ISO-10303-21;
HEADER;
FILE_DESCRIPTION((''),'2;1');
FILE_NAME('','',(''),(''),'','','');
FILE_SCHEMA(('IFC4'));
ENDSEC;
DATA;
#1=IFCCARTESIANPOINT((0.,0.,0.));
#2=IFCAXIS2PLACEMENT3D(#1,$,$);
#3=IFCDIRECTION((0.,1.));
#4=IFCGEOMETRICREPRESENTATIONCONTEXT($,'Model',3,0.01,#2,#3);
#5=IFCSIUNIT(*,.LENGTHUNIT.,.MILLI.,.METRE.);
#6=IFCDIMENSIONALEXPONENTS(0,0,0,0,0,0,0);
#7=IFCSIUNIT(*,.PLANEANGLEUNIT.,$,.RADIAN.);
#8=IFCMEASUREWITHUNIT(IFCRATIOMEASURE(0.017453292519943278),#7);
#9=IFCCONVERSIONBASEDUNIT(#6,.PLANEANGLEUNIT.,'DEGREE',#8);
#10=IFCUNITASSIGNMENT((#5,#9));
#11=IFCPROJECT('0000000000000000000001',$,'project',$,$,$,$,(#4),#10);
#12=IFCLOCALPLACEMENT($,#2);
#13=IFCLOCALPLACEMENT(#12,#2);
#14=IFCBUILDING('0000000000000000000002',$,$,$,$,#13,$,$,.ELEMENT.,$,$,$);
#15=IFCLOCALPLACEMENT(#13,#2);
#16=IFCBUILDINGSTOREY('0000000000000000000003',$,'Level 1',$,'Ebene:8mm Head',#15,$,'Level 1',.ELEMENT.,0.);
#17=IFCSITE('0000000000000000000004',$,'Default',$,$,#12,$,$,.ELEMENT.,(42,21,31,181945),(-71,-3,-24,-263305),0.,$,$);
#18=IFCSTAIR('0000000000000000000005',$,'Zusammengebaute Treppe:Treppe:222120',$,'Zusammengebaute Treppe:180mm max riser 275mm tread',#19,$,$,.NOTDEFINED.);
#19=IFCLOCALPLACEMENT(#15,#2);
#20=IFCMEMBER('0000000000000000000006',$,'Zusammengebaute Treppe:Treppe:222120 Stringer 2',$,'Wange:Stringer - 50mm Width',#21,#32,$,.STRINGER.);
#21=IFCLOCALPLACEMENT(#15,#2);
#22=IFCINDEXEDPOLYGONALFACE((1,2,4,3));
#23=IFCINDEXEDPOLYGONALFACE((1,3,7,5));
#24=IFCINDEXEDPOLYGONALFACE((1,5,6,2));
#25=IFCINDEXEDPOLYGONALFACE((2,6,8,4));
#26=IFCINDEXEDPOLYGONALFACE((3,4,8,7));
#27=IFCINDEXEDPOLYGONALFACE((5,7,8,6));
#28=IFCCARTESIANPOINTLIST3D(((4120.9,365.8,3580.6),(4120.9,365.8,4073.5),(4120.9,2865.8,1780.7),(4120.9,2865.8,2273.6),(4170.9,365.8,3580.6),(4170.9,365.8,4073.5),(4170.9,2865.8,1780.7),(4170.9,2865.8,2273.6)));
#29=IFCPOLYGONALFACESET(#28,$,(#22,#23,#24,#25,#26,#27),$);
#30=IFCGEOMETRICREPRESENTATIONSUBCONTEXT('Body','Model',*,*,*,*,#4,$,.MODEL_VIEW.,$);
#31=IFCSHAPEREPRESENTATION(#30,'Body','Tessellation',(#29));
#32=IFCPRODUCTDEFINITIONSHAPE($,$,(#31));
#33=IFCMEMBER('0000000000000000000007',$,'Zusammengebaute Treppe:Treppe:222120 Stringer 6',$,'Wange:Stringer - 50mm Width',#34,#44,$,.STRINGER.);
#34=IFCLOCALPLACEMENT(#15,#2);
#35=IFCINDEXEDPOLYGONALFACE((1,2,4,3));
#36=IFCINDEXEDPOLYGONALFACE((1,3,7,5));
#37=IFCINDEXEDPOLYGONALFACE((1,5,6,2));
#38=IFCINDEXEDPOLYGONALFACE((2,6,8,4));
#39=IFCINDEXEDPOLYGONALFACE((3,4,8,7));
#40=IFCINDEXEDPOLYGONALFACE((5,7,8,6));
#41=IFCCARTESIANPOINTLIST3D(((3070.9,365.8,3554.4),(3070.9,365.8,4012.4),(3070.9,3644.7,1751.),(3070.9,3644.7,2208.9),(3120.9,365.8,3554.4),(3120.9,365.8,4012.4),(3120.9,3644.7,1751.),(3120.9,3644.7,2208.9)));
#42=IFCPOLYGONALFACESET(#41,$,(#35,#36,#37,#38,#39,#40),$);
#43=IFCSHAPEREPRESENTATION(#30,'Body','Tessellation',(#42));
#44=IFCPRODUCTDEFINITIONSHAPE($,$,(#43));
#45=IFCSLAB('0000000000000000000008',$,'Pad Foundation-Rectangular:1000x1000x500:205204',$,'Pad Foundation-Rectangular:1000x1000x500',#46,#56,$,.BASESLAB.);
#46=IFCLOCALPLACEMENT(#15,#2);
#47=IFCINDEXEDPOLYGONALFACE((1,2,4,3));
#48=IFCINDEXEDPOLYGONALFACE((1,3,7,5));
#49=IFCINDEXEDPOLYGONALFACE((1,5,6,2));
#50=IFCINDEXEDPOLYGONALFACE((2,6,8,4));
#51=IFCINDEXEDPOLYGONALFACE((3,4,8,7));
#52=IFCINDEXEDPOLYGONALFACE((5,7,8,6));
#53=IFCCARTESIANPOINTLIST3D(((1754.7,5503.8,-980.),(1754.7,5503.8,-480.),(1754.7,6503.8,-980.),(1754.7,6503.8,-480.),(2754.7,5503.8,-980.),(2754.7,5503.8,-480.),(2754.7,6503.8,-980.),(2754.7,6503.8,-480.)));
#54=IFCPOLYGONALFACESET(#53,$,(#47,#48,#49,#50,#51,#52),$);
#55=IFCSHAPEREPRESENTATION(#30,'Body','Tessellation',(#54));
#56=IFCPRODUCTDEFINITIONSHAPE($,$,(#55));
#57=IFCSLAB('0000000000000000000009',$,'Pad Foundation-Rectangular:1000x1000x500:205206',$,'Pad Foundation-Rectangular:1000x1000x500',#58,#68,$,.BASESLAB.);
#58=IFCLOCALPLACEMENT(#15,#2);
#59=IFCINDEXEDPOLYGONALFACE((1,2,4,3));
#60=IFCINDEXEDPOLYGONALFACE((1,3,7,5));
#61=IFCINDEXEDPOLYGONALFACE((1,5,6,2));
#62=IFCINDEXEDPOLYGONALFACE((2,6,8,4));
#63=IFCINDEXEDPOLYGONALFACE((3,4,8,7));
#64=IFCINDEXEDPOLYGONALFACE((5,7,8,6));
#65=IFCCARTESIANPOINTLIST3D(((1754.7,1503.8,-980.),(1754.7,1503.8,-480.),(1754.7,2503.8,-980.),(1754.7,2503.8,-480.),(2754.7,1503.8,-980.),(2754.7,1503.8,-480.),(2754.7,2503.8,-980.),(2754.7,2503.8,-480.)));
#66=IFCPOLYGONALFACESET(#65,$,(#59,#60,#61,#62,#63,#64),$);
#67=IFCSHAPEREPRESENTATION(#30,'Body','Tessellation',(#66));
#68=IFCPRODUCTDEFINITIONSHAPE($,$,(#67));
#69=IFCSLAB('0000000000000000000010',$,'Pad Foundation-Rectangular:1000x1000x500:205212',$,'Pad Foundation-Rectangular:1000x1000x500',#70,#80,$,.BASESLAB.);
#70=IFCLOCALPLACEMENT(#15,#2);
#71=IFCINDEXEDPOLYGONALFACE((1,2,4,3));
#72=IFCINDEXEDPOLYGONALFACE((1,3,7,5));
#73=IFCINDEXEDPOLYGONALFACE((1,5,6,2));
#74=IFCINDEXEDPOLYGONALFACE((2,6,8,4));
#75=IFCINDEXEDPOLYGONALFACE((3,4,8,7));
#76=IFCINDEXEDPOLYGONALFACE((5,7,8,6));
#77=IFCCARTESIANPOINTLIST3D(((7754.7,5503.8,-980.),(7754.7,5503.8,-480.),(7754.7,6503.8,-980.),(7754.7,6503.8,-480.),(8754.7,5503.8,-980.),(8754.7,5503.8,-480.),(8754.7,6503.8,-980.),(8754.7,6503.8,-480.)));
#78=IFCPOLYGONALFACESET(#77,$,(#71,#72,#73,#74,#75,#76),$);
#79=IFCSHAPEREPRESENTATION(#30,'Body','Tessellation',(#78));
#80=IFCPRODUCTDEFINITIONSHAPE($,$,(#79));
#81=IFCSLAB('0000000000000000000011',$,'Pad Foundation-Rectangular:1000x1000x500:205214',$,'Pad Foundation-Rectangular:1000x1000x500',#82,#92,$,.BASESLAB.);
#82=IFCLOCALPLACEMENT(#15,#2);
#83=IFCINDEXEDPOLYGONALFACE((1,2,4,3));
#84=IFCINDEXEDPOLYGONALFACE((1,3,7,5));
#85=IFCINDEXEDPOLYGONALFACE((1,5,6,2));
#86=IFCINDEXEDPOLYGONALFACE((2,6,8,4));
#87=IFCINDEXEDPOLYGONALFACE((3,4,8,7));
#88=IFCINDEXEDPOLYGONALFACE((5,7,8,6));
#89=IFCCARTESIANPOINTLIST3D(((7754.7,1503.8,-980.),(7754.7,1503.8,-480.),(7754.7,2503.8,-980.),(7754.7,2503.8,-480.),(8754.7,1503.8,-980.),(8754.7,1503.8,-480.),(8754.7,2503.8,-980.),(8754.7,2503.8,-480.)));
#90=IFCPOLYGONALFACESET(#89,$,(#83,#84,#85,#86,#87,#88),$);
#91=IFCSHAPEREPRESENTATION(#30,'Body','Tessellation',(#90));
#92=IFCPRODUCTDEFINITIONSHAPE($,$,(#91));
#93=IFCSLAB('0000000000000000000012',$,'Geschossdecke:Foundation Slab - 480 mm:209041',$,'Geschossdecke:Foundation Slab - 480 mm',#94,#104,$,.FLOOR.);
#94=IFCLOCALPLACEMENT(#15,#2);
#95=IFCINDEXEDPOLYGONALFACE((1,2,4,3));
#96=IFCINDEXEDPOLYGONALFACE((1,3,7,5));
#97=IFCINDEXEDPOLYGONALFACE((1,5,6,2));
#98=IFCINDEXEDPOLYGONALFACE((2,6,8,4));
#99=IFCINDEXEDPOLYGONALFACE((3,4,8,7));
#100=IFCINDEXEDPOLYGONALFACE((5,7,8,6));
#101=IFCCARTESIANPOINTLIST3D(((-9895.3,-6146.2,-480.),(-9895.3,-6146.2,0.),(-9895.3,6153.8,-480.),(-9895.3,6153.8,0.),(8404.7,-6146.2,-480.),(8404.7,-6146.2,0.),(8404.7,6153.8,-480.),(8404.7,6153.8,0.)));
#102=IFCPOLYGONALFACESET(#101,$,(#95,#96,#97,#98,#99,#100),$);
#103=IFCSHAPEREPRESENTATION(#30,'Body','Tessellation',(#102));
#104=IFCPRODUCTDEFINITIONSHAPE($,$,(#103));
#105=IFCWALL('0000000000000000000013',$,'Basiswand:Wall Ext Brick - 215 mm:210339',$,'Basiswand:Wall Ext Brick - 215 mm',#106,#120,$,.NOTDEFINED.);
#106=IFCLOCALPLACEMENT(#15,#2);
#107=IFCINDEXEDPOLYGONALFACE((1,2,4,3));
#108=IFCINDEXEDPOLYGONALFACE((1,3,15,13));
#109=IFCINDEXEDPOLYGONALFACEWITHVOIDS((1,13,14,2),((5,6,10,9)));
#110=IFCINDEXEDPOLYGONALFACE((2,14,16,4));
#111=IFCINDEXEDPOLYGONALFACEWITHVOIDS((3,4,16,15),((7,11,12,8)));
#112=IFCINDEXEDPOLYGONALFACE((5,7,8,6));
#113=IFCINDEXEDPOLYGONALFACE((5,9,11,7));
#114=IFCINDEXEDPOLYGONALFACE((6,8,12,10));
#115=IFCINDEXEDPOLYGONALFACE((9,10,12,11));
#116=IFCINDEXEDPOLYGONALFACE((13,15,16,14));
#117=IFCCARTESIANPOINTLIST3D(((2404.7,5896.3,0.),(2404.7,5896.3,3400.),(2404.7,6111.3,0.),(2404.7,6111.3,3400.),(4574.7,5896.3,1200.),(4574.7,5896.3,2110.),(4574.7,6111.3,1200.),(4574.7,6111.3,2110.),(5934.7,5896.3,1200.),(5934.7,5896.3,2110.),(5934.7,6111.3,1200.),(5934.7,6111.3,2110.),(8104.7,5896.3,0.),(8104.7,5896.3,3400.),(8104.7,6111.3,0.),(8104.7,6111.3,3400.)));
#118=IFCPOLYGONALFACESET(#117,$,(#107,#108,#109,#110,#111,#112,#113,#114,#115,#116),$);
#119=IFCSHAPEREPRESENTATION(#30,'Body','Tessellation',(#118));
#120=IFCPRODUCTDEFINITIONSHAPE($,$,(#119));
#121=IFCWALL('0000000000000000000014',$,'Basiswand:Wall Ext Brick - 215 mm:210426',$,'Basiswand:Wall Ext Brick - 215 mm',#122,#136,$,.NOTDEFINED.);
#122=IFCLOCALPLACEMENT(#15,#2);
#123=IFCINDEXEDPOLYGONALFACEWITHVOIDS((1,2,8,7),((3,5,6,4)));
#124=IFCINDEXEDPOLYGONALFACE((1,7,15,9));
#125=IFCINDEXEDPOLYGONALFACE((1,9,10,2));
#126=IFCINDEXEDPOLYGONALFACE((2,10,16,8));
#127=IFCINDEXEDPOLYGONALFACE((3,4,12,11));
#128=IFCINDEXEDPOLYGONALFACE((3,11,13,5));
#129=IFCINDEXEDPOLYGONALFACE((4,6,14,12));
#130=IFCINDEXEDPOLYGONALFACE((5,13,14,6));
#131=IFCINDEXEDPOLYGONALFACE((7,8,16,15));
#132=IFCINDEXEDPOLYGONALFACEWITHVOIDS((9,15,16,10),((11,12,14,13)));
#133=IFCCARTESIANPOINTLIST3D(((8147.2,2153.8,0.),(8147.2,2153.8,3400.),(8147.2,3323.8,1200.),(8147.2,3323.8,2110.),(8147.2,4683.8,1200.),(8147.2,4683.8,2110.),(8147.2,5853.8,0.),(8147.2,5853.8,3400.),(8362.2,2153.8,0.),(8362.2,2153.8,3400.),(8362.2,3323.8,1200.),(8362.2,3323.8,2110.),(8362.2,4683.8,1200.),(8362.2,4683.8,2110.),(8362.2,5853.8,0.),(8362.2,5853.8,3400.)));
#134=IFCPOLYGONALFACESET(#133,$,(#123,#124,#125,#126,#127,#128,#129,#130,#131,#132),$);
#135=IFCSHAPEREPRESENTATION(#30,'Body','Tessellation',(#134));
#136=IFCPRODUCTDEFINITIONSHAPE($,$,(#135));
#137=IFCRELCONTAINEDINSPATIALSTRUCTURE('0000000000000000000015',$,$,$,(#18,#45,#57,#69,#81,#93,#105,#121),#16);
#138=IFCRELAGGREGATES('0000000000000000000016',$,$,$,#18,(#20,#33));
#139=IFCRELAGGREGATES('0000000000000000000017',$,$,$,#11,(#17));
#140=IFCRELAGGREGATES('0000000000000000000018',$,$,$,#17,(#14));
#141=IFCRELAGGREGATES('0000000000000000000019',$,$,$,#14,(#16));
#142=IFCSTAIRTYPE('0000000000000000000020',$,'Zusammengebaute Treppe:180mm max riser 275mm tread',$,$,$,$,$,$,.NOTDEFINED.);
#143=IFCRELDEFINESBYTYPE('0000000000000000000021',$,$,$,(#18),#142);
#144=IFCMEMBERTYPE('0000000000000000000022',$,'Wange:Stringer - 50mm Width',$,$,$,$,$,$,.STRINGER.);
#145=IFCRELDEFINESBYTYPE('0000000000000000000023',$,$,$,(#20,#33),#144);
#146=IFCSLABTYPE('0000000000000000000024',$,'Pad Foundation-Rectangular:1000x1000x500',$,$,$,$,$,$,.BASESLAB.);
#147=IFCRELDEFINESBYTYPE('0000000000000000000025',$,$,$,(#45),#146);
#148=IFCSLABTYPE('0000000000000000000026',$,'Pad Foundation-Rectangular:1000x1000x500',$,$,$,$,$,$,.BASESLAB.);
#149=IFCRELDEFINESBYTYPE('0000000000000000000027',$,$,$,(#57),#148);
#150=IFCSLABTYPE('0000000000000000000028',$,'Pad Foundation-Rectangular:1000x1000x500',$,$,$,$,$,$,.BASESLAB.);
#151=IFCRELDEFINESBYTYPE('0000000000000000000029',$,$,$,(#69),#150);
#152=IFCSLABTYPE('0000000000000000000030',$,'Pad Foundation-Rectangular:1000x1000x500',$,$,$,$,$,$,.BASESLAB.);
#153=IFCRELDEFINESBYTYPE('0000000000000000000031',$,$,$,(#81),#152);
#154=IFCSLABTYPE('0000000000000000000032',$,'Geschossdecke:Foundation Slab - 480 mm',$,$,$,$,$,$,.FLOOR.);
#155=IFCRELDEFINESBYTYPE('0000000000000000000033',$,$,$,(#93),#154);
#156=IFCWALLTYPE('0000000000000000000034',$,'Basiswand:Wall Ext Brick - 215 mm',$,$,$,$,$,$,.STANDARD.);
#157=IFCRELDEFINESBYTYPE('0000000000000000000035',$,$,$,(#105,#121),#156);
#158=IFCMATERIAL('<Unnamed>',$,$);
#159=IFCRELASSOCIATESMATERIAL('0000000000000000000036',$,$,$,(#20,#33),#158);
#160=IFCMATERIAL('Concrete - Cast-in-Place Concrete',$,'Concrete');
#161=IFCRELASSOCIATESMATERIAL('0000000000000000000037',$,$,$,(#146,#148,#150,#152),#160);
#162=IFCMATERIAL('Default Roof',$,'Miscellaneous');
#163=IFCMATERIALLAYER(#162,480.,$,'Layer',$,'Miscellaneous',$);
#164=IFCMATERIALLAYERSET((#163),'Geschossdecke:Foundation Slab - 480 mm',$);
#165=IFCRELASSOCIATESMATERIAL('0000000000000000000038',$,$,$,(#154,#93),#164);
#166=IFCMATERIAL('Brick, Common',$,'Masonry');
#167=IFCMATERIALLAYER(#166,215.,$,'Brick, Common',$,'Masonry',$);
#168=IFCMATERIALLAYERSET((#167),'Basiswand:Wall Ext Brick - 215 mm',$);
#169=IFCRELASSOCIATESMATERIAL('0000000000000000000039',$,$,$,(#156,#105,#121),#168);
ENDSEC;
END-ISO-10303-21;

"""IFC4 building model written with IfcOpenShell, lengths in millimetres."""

from ifc_helpers import new_model, entity, si_unit, converted_unit, direction, frame, frame_2d, origin, origin_2d_with_axis, place, context, subcontext, project, spatial, polyline, rectangle, outline, extrude, material, layer, layer_set, layer_usage, type_object, element, aggregate, save


model = new_model("IFC4")

# Units and contexts
model_context = context("Model", 3, precision=0.01, world=origin(), true_north=direction((0.0, 1.0)))
body_context = subcontext(model_context, "Body", "Model", "MODEL_VIEW")
ifc_project = project(units=[si_unit("LENGTHUNIT", "METRE", prefix="MILLI"), converted_unit("PLANEANGLEUNIT", "DEGREE", entity("IfcRatioMeasure", 0.017453292519943278), si_unit("PLANEANGLEUNIT", "RADIAN"), dimensions=[0, 0, 0, 0, 0, 0, 0])], contexts=[model_context])

# Site, building, storey
site_placement = place(None, origin())
site = spatial("IfcSite", under=ifc_project, at=site_placement, Name="Default", CompositionType="ELEMENT", RefLatitude=(42, 21, 31, 181945), RefLongitude=(-71, -3, -24, -263305), RefElevation=0.0)
building_placement = place(site_placement, origin())
building = spatial("IfcBuilding", under=site, at=building_placement, CompositionType="ELEMENT")
storey_placement = place(building_placement, origin())
storey = spatial("IfcBuildingStorey", under=building, at=storey_placement, Name="Level 1", ObjectType="Ebene:8mm Head", LongName="Level 1", CompositionType="ELEMENT", Elevation=0.0)

# Shared definitions
ifc_material_1 = material(Name="Concrete - Cast-in-Place Concrete", Category="Concrete")

# Stair, members
stair_type = type_object("IfcStairType", Name="Zusammengebaute Treppe:180mm max riser 275mm tread", PredefinedType="NOTDEFINED")
stair_placement = place(storey_placement, origin())
stair = element("IfcStair", 1, at=stair_placement, inside=storey, type_object=stair_type, Name="Zusammengebaute Treppe:Treppe:222120", ObjectType="Zusammengebaute Treppe:180mm max riser 275mm tread", PredefinedType="NOTDEFINED")
ifc_material_2 = material(Name="<Unnamed>")
member_type = type_object("IfcMemberType", Name="Wange:Stringer - 50mm Width", PredefinedType="STRINGER")
member_1_placement = place(stair_placement, frame((4120.9, 365.8, 1780.7)))
member_1 = element("IfcMember", 2, at=member_1_placement, type_object=member_type, material=ifc_material_2, Name="Zusammengebaute Treppe:Treppe:222120 Stringer 2", ObjectType="Wange:Stringer - 50mm Width", PredefinedType="STRINGER", context=body_context, shape_type="SweptSolid", body=[
    extrude(outline(polyline([(-1396.3, -200.0), (1684.2, -200.0), (1396.3, 200.0), (-1684.2, 200.0), (-1396.3, -200.0)])), frame((0.0, 1250.0, 1146.4), z_axis=(1.0, 0.0, 0.0), x_axis=(0.0, -0.81156, 0.584269)), (0.0, 0.0, 1.0), 50.0),
])
member_2_placement = place(stair_placement, frame((3070.9, 365.8, 1751.0)))
member_2 = element("IfcMember", 3, at=member_2_placement, type_object=member_type, material=ifc_material_2, Name="Zusammengebaute Treppe:Treppe:222120 Stringer 6", ObjectType="Wange:Stringer - 50mm Width", PredefinedType="STRINGER", context=body_context, shape_type="SweptSolid", body=[
    extrude(outline(polyline([(-1760.7, -200.6), (1981.4, -200.6), (1760.7, 200.6), (-1981.4, 200.6), (-1760.7, -200.6)])), frame((0.0, 1639.4, 1130.7), z_axis=(1.0, 0.0, 0.0), x_axis=(0.0, -0.876209, 0.481931)), (0.0, 0.0, 1.0), 50.0),
])
aggregate(stair, [member_1, member_2])

# Slabs
slab_type_1 = type_object("IfcSlabType", Name="Pad Foundation-Rectangular:1000x1000x500", PredefinedType="BASESLAB", material=ifc_material_1)
slab_1_placement = place(storey_placement, frame((1754.7, 5503.8, -980.0)))
element("IfcSlab", 4, at=slab_1_placement, inside=storey, type_object=slab_type_1, Name="Pad Foundation-Rectangular:1000x1000x500:205204", ObjectType="Pad Foundation-Rectangular:1000x1000x500", PredefinedType="BASESLAB", context=body_context, shape_type="SweptSolid", body=[
    extrude(rectangle(XDim=1000.0, YDim=1000.0, at=frame_2d((0.0, 0.0), x_axis=(1.0, 0.0))), frame((500.0, 500.0, 0.0), z_axis=(0.0, 0.0, 1.0), x_axis=(-1.0, 0.0, 0.0)), (0.0, 0.0, 1.0), 500.0),
])
slab_type_2 = type_object("IfcSlabType", Name="Pad Foundation-Rectangular:1000x1000x500", PredefinedType="BASESLAB", material=ifc_material_1)
slab_2_placement = place(storey_placement, frame((1754.7, 1503.8, -980.0)))
element("IfcSlab", 5, at=slab_2_placement, inside=storey, type_object=slab_type_2, Name="Pad Foundation-Rectangular:1000x1000x500:205206", ObjectType="Pad Foundation-Rectangular:1000x1000x500", PredefinedType="BASESLAB", context=body_context, shape_type="SweptSolid", body=[
    extrude(rectangle(XDim=1000.0, YDim=1000.0, at=origin_2d_with_axis()), frame((500.0, 500.0, 0.0), z_axis=(0.0, 0.0, 1.0), x_axis=(-1.0, 0.0, 0.0)), (0.0, 0.0, 1.0), 500.0),
])
slab_type_3 = type_object("IfcSlabType", Name="Pad Foundation-Rectangular:1000x1000x500", PredefinedType="BASESLAB", material=ifc_material_1)
slab_3_placement = place(storey_placement, frame((7754.7, 5503.8, -980.0)))
element("IfcSlab", 6, at=slab_3_placement, inside=storey, type_object=slab_type_3, Name="Pad Foundation-Rectangular:1000x1000x500:205212", ObjectType="Pad Foundation-Rectangular:1000x1000x500", PredefinedType="BASESLAB", context=body_context, shape_type="SweptSolid", body=[
    extrude(rectangle(XDim=1000.0, YDim=1000.0, at=frame_2d((0.0, 0.0), x_axis=(1.0, 0.0))), frame((500.0, 500.0, 0.0), z_axis=(0.0, 0.0, 1.0), x_axis=(-1.0, 0.0, 0.0)), (0.0, 0.0, 1.0), 500.0),
])
slab_type_4 = type_object("IfcSlabType", Name="Pad Foundation-Rectangular:1000x1000x500", PredefinedType="BASESLAB", material=ifc_material_1)
slab_4_placement = place(storey_placement, frame((7754.7, 1503.8, -980.0)))
element("IfcSlab", 7, at=slab_4_placement, inside=storey, type_object=slab_type_4, Name="Pad Foundation-Rectangular:1000x1000x500:205214", ObjectType="Pad Foundation-Rectangular:1000x1000x500", PredefinedType="BASESLAB", context=body_context, shape_type="SweptSolid", body=[
    extrude(rectangle(XDim=1000.0, YDim=1000.0, at=frame_2d((0.0, 0.0), x_axis=(1.0, 0.0))), frame((500.0, 500.0, 0.0), z_axis=(0.0, 0.0, 1.0), x_axis=(-1.0, 0.0, 0.0)), (0.0, 0.0, 1.0), 500.0),
])
ifc_material_3 = material(Name="Default Roof", Category="Miscellaneous")
ifc_layer_1 = layer(ifc_material_3, 480.0, Name="Layer", Category="Miscellaneous")
ifc_layer_set_1 = layer_set([ifc_layer_1], Name="Geschossdecke:Foundation Slab - 480 mm")
ifc_layer_usage_1 = layer_usage(ifc_layer_set_1, "AXIS3", "POSITIVE", 0.0)
slab_type_5 = type_object("IfcSlabType", Name="Geschossdecke:Foundation Slab - 480 mm", PredefinedType="FLOOR", material=ifc_layer_set_1)
slab_5_placement = place(storey_placement, origin())
element("IfcSlab", 8, at=slab_5_placement, inside=storey, type_object=slab_type_5, material=ifc_layer_usage_1, Name="Geschossdecke:Foundation Slab - 480 mm:209041", ObjectType="Geschossdecke:Foundation Slab - 480 mm", PredefinedType="FLOOR", context=body_context, shape_type="SweptSolid", body=[
    extrude(rectangle(XDim=12300.0, YDim=18300.0, at=origin_2d_with_axis()), frame((-745.3, 3.8, 0.0), z_axis=(0.0, 0.0, -1.0), x_axis=(0.0, 1.0, 0.0)), (0.0, 0.0, 1.0), 480.0),
])

# Walls, openings
ifc_material_4 = material(Name="Brick, Common", Category="Masonry")
ifc_layer_2 = layer(ifc_material_4, 215.0, Name="Brick, Common", Category="Masonry")
ifc_layer_set_2 = layer_set([ifc_layer_2], Name="Basiswand:Wall Ext Brick - 215 mm")
ifc_layer_usage_2 = layer_usage(ifc_layer_set_2, "AXIS2", "NEGATIVE", 107.5)
wall_type = type_object("IfcWallType", Name="Basiswand:Wall Ext Brick - 215 mm", PredefinedType="STANDARD", material=ifc_layer_set_2)
wall_1_placement = place(storey_placement, frame((2404.7, 6003.8, 0.0)))
wall_1 = element("IfcWall", 9, at=wall_1_placement, inside=storey, type_object=wall_type, material=ifc_layer_usage_2, Name="Basiswand:Wall Ext Brick - 215 mm:210339", ObjectType="Basiswand:Wall Ext Brick - 215 mm", PredefinedType="NOTDEFINED", context=body_context, shape_type="SweptSolid", body=[
    extrude(rectangle(XDim=5700.0, YDim=215.0, at=frame_2d((2850.0, 0.0), x_axis=(-1.0, 0.0))), origin(), (0.0, 0.0, 1.0), 3400.0),
])
opening_1_placement = place(wall_1_placement, frame((2170.0, -107.5, 1200.0)))
element("IfcOpeningElement", 10, at=opening_1_placement, cuts=wall_1, PredefinedType="OPENING", context=body_context, shape_type="SweptSolid", body=[
    extrude(rectangle(XDim=910.0, YDim=1360.0, at=frame_2d((455.0, 680.0), x_axis=(-1.0, 0.0))), frame((0.0, 0.0, 0.0), z_axis=(0.0, 1.0, 0.0), x_axis=(0.0, 0.0, 1.0)), (0.0, 0.0, 1.0), 215.0),
])
ifc_layer_usage_3 = layer_usage(ifc_layer_set_2, "AXIS2", "NEGATIVE", 107.5)
wall_2_placement = place(storey_placement, frame((8254.7, 2153.8, 0.0), z_axis=(0.0, 0.0, 1.0), x_axis=(0.0, 1.0, 0.0)))
wall_2 = element("IfcWall", 11, at=wall_2_placement, inside=storey, type_object=wall_type, material=ifc_layer_usage_3, Name="Basiswand:Wall Ext Brick - 215 mm:210426", ObjectType="Basiswand:Wall Ext Brick - 215 mm", PredefinedType="NOTDEFINED", context=body_context, shape_type="SweptSolid", body=[
    extrude(rectangle(XDim=3700.0, YDim=215.0, at=frame_2d((1850.0, 0.0), x_axis=(-1.0, 0.0))), origin(), (0.0, 0.0, 1.0), 3400.0),
])
opening_2_placement = place(wall_2_placement, frame((1170.0, -107.5, 1200.0)))
element("IfcOpeningElement", 12, at=opening_2_placement, cuts=wall_2, PredefinedType="OPENING", context=body_context, shape_type="SweptSolid", body=[
    extrude(rectangle(XDim=910.0, YDim=1360.0, at=frame_2d((455.0, 680.0), x_axis=(-1.0, 0.0))), frame((0.0, 0.0, 0.0), z_axis=(0.0, 1.0, 0.0), x_axis=(0.0, 0.0, 1.0)), (0.0, 0.0, 1.0), 215.0),
])

save(model, "model.ifc")
